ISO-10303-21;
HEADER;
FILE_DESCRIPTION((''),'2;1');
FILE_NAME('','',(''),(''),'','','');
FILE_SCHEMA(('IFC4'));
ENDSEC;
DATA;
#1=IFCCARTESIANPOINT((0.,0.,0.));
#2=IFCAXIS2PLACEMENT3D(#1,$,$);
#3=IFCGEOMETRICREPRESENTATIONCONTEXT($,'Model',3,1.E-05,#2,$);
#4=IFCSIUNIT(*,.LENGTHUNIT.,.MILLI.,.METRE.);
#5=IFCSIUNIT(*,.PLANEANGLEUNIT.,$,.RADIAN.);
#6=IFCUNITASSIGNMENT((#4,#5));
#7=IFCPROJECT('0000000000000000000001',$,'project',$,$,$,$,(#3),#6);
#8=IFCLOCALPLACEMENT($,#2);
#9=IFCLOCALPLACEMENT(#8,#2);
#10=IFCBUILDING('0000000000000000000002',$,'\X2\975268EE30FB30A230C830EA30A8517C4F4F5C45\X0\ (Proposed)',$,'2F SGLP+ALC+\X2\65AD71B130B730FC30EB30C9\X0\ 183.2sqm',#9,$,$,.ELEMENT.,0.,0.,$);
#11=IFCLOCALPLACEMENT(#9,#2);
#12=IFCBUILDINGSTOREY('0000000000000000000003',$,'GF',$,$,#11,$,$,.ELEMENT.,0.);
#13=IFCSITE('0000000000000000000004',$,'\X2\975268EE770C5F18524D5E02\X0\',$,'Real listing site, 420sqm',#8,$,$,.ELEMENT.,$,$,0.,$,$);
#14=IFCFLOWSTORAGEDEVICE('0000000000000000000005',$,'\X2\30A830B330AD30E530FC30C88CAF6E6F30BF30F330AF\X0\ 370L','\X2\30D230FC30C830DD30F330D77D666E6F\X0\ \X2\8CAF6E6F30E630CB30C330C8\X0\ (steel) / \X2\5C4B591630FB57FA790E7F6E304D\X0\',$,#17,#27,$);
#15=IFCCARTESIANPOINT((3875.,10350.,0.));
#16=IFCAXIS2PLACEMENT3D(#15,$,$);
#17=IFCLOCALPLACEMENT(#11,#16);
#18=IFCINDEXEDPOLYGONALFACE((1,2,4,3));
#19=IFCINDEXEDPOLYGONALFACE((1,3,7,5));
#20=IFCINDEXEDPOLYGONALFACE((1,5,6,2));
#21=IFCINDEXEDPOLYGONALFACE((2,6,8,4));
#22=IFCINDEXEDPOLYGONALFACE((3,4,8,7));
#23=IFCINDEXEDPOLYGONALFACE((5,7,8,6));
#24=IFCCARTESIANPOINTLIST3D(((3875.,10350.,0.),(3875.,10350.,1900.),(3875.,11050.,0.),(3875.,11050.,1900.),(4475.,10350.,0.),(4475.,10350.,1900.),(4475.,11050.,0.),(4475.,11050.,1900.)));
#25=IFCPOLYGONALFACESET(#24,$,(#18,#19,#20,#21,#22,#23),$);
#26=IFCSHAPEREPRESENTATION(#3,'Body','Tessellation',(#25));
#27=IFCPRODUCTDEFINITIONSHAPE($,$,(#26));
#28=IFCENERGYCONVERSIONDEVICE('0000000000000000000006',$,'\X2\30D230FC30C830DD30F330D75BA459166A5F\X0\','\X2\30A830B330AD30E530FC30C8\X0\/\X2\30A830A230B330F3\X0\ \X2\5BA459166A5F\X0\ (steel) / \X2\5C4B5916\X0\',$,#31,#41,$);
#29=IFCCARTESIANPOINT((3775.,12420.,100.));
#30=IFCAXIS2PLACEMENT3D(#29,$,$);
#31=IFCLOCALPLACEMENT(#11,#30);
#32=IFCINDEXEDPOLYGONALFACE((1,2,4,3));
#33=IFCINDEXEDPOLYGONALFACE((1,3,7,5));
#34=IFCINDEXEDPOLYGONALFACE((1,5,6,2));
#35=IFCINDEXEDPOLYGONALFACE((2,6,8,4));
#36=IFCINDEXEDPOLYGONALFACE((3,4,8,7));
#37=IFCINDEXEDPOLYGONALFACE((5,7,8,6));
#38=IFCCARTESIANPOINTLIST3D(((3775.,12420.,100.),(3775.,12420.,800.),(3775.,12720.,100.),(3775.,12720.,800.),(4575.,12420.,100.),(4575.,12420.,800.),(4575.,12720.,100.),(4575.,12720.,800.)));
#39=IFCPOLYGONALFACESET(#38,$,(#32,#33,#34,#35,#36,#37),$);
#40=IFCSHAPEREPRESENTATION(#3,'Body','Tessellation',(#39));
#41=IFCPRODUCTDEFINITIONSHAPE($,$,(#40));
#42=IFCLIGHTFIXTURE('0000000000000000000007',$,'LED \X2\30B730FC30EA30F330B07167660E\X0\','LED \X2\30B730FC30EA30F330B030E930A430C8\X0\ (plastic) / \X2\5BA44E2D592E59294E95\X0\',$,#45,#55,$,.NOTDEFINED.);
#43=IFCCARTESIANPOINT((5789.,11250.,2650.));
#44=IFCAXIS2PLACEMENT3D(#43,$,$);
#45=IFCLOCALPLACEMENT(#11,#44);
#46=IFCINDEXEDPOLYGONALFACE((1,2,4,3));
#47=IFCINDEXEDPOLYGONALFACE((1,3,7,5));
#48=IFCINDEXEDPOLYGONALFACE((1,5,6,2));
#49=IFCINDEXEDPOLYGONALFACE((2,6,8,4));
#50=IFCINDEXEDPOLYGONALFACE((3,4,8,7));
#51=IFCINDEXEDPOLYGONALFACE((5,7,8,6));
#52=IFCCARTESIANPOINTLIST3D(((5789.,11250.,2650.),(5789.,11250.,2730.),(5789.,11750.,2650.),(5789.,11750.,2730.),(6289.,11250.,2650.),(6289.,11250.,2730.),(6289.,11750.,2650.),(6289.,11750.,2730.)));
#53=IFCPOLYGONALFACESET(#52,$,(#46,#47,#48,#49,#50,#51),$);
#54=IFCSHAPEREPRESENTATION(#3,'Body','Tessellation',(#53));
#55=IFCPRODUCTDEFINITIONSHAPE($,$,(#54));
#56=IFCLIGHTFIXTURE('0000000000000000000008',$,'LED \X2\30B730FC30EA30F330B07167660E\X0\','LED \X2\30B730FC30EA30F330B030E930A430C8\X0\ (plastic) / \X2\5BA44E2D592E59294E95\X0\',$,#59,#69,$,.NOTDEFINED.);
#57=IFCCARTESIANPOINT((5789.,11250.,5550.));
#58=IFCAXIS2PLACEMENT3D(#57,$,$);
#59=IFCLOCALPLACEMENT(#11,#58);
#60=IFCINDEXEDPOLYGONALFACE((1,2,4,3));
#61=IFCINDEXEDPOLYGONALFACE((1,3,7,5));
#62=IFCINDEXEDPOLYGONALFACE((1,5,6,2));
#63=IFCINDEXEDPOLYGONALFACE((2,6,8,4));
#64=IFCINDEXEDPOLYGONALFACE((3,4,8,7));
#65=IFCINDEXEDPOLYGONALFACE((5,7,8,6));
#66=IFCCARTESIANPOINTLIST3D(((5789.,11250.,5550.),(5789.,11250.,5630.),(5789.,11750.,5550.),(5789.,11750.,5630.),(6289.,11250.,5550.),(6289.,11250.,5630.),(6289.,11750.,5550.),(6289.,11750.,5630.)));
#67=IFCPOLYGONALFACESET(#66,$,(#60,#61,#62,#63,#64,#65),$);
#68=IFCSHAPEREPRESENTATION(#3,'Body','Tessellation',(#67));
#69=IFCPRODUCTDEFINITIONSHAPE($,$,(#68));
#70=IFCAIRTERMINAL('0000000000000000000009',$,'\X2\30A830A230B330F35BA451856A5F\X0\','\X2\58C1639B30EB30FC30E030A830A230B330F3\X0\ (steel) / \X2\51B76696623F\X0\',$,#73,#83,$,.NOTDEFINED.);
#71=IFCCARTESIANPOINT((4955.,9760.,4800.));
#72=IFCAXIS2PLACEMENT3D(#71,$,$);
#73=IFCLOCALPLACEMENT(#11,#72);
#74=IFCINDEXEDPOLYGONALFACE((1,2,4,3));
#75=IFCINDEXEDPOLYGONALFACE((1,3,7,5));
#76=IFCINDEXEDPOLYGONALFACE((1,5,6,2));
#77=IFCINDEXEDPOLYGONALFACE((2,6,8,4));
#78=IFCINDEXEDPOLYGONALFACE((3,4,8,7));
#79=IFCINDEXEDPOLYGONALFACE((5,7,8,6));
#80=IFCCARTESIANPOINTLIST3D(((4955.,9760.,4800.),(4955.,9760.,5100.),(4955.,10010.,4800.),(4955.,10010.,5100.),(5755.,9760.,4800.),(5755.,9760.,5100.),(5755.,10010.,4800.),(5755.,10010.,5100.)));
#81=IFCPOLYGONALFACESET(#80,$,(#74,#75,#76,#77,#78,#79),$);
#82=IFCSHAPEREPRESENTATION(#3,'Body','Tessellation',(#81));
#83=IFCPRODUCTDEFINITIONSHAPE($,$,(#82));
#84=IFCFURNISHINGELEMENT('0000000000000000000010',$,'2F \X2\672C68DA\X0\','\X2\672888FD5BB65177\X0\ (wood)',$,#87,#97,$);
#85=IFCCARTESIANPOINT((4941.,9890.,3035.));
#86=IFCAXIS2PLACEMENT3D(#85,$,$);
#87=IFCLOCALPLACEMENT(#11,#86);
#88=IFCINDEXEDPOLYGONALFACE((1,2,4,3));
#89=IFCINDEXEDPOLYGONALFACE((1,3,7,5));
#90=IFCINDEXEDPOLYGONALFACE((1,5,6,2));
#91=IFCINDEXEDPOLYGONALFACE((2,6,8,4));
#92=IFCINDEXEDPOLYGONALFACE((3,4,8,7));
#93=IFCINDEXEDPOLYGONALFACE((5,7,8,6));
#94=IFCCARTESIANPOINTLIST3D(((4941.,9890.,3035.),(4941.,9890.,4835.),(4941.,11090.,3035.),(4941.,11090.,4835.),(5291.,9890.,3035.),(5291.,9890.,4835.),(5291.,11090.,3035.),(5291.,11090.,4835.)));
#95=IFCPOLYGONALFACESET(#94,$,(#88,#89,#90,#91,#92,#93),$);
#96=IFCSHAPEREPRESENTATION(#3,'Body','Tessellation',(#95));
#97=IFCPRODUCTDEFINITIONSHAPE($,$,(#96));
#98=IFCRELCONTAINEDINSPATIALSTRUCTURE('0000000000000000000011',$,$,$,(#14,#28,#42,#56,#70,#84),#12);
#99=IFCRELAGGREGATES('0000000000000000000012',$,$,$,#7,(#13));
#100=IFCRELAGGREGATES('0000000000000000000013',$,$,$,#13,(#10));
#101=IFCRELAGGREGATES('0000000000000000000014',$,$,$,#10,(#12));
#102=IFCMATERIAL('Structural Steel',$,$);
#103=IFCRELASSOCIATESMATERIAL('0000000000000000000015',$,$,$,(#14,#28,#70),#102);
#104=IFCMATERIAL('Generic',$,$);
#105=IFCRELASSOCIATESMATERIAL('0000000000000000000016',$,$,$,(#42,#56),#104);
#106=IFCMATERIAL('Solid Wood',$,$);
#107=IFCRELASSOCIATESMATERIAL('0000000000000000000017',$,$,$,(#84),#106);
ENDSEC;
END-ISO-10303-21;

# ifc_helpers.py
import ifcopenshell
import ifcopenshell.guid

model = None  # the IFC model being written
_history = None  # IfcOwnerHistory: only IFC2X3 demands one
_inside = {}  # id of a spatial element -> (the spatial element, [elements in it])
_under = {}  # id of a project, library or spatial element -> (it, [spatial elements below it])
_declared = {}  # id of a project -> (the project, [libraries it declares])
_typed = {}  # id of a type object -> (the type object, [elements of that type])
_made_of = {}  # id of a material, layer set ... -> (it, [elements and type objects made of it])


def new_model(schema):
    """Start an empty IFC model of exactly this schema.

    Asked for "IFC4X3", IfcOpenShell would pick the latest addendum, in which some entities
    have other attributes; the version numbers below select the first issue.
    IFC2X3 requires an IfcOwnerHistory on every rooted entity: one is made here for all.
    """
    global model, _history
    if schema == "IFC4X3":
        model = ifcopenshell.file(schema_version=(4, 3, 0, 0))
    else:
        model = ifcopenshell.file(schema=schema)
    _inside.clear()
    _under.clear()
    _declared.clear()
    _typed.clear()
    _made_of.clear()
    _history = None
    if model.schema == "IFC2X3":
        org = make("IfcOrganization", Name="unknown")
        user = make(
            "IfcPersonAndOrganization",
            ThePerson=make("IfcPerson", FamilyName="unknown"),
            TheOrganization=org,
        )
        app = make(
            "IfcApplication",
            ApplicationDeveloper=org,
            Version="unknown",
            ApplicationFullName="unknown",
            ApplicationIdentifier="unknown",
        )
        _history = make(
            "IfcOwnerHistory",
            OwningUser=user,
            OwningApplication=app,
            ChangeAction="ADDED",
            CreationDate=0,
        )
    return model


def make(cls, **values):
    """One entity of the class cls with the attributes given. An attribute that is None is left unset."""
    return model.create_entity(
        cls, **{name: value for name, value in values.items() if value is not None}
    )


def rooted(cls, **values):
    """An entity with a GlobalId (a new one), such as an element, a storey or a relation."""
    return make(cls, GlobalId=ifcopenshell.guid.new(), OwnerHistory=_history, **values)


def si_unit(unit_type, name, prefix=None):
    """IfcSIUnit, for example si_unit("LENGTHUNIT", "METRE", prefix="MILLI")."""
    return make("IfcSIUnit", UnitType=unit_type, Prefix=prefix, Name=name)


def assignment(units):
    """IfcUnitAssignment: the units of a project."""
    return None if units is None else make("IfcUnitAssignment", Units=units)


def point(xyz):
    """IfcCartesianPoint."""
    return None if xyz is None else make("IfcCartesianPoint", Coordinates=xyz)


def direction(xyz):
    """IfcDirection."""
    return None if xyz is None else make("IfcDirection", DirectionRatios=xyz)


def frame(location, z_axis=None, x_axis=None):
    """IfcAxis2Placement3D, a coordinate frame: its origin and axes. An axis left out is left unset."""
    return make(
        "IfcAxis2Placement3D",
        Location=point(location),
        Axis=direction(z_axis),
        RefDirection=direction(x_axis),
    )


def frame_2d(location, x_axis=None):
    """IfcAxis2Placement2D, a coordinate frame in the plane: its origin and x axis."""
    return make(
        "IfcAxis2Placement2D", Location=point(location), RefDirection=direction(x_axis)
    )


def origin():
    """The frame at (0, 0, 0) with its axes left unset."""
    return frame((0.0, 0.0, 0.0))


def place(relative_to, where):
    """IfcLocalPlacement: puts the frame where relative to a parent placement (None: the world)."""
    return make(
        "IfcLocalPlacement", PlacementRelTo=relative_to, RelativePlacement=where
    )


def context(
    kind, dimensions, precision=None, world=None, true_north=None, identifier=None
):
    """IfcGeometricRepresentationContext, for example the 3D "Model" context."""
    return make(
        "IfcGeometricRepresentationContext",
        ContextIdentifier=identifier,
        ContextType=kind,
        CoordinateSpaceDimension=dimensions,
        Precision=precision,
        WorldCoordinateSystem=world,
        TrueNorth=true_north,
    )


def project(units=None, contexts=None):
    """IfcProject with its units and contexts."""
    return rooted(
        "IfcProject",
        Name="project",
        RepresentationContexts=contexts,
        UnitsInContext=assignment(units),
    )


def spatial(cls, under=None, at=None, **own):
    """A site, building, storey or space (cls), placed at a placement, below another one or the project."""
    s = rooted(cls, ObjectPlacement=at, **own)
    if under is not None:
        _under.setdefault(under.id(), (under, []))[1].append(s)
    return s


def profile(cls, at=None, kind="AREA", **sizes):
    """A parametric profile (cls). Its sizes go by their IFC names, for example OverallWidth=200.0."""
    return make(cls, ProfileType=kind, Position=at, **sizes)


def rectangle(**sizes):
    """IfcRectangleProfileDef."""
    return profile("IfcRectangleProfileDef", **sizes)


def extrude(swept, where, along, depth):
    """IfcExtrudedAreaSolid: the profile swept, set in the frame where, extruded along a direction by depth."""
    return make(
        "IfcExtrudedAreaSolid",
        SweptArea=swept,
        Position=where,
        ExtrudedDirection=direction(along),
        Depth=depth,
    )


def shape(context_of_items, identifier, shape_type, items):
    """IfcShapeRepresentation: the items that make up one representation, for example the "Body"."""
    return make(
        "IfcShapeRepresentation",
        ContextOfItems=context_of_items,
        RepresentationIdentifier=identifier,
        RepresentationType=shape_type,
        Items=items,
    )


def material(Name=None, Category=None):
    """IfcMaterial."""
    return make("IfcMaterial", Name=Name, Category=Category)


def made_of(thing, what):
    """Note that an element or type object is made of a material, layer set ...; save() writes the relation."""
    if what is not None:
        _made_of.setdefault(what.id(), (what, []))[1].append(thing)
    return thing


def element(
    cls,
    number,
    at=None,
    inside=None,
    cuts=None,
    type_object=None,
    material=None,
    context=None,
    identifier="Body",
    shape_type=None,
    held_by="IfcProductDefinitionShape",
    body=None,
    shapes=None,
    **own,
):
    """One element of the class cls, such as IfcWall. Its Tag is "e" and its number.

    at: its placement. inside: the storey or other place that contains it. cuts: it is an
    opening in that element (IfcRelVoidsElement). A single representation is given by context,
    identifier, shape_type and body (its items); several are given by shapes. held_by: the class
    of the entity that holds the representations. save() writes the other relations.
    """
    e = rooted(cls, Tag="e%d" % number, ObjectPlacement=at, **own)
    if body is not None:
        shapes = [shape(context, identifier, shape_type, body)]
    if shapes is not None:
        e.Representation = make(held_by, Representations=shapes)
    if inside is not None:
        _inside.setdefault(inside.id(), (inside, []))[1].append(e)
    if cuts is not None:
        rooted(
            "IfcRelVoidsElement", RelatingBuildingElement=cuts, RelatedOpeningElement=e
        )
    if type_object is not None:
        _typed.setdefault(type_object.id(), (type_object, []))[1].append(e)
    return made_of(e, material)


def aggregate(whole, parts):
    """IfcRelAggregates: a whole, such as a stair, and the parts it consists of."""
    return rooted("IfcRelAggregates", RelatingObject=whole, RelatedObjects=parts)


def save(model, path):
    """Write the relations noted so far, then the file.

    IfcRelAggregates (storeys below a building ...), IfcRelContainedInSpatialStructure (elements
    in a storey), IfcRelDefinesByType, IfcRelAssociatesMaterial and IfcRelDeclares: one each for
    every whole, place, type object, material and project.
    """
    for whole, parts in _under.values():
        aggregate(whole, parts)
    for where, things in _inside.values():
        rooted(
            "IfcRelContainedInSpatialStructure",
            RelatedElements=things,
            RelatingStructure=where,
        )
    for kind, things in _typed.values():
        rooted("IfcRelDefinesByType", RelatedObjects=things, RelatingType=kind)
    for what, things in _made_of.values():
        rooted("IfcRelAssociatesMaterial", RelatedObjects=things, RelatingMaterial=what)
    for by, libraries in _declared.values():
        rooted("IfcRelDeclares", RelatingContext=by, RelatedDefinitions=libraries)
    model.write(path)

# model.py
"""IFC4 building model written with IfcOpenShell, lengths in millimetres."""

from ifc_helpers import new_model, si_unit, frame, frame_2d, origin, place, context, project, spatial, rectangle, extrude, material, element, save


model = new_model("IFC4")

# Units and contexts
model_context = context("Model", 3, precision=1e-05, world=origin())
ifc_project = project(units=[si_unit("LENGTHUNIT", "METRE", prefix="MILLI"), si_unit("PLANEANGLEUNIT", "RADIAN")], contexts=[model_context])

# Site, building, storey
site_placement = place(None, origin())
site = spatial("IfcSite", under=ifc_project, at=site_placement, Name="青森県弘前市", ObjectType="Real listing site, 420sqm", CompositionType="ELEMENT", RefElevation=0.0)
building_placement = place(site_placement, origin())
building = spatial("IfcBuilding", under=site, at=building_placement, Name="青森・アトリエ兼住居 (Proposed)", ObjectType="2F SGLP+ALC+断熱シールド 183.2sqm", CompositionType="ELEMENT", ElevationOfRefHeight=0.0, ElevationOfTerrain=0.0)
storey_placement = place(building_placement, origin())
storey = spatial("IfcBuildingStorey", under=building, at=storey_placement, Name="GF", CompositionType="ELEMENT", Elevation=0.0)

# Shared definitions
ifc_material_1 = material(Name="Solid Wood")

# Shared definitions
ifc_material_2 = material(Name="Structural Steel")

# Shared definitions
ifc_material_3 = material(Name="Generic")

# Flow storage device
flow_storage_device_placement = place(storey_placement, frame((3875.0, 10350.0, 0.0)))
element("IfcFlowStorageDevice", 1, at=flow_storage_device_placement, inside=storey, material=ifc_material_2, Name="エコキュート貯湯タンク 370L", Description="ヒートポンプ給湯 貯湯ユニット (steel) / 屋外・基礎置き", context=model_context, shape_type="SweptSolid", body=[
    extrude(rectangle(XDim=600.0, YDim=700.0, at=frame_2d((300.0, 350.0))), frame((3875.0, 10350.0, 0.0)), (0.0, 0.0, 1.0), 1900.0),
])

# Energy conversion device
energy_conversion_device_placement = place(storey_placement, frame((3775.0, 12420.0, 100.0)))
element("IfcEnergyConversionDevice", 2, at=energy_conversion_device_placement, inside=storey, material=ifc_material_2, Name="ヒートポンプ室外機", Description="エコキュート/エアコン 室外機 (steel) / 屋外", context=model_context, shape_type="SweptSolid", body=[
    extrude(rectangle(XDim=800.0, YDim=300.0, at=frame_2d((400.0, 150.0))), frame((3775.0, 12420.0, 100.0)), (0.0, 0.0, 1.0), 700.0),
])

# Light fixtures
light_fixture_1_placement = place(storey_placement, frame((5789.0, 11250.0, 2650.0)))
element("IfcLightFixture", 3, at=light_fixture_1_placement, inside=storey, material=ifc_material_3, Name="LED シーリング照明", Description="LED シーリングライト (plastic) / 室中央天井", PredefinedType="NOTDEFINED", context=model_context, shape_type="SweptSolid", body=[
    extrude(rectangle(XDim=500.0, YDim=500.0, at=frame_2d((250.0, 250.0))), frame((5789.0, 11250.0, 2650.0)), (0.0, 0.0, 1.0), 80.0),
])
light_fixture_2_placement = place(storey_placement, frame((5789.0, 11250.0, 5550.0)))
element("IfcLightFixture", 4, at=light_fixture_2_placement, inside=storey, material=ifc_material_3, Name="LED シーリング照明", Description="LED シーリングライト (plastic) / 室中央天井", PredefinedType="NOTDEFINED", context=model_context, shape_type="SweptSolid", body=[
    extrude(rectangle(XDim=500.0, YDim=500.0, at=frame_2d((250.0, 250.0))), frame((5789.0, 11250.0, 5550.0)), (0.0, 0.0, 1.0), 80.0),
])

# Air terminal
air_terminal_placement = place(storey_placement, frame((4955.0, 9760.0, 4800.0)))
element("IfcAirTerminal", 5, at=air_terminal_placement, inside=storey, material=ifc_material_2, Name="エアコン室内機", Description="壁掛ルームエアコン (steel) / 冷暖房", PredefinedType="NOTDEFINED", context=model_context, shape_type="SweptSolid", body=[
    extrude(rectangle(XDim=800.0, YDim=250.0, at=frame_2d((400.0, 125.0))), frame((4955.0, 9760.0, 4800.0)), (0.0, 0.0, 1.0), 300.0),
])

# Furnishing element
furnishing_placement = place(storey_placement, frame((4941.0, 9890.0, 3035.0)))
element("IfcFurnishingElement", 6, at=furnishing_placement, inside=storey, material=ifc_material_1, Name="2F 本棚", Description="木製家具 (wood)", context=model_context, shape_type="SweptSolid", body=[
    extrude(rectangle(XDim=350.0, YDim=1200.0, at=frame_2d((175.0, 600.0))), frame((4941.0, 9890.0, 3035.0)), (0.0, 0.0, 1.0), 1800.0),
])

save(model, "model.ifc")
